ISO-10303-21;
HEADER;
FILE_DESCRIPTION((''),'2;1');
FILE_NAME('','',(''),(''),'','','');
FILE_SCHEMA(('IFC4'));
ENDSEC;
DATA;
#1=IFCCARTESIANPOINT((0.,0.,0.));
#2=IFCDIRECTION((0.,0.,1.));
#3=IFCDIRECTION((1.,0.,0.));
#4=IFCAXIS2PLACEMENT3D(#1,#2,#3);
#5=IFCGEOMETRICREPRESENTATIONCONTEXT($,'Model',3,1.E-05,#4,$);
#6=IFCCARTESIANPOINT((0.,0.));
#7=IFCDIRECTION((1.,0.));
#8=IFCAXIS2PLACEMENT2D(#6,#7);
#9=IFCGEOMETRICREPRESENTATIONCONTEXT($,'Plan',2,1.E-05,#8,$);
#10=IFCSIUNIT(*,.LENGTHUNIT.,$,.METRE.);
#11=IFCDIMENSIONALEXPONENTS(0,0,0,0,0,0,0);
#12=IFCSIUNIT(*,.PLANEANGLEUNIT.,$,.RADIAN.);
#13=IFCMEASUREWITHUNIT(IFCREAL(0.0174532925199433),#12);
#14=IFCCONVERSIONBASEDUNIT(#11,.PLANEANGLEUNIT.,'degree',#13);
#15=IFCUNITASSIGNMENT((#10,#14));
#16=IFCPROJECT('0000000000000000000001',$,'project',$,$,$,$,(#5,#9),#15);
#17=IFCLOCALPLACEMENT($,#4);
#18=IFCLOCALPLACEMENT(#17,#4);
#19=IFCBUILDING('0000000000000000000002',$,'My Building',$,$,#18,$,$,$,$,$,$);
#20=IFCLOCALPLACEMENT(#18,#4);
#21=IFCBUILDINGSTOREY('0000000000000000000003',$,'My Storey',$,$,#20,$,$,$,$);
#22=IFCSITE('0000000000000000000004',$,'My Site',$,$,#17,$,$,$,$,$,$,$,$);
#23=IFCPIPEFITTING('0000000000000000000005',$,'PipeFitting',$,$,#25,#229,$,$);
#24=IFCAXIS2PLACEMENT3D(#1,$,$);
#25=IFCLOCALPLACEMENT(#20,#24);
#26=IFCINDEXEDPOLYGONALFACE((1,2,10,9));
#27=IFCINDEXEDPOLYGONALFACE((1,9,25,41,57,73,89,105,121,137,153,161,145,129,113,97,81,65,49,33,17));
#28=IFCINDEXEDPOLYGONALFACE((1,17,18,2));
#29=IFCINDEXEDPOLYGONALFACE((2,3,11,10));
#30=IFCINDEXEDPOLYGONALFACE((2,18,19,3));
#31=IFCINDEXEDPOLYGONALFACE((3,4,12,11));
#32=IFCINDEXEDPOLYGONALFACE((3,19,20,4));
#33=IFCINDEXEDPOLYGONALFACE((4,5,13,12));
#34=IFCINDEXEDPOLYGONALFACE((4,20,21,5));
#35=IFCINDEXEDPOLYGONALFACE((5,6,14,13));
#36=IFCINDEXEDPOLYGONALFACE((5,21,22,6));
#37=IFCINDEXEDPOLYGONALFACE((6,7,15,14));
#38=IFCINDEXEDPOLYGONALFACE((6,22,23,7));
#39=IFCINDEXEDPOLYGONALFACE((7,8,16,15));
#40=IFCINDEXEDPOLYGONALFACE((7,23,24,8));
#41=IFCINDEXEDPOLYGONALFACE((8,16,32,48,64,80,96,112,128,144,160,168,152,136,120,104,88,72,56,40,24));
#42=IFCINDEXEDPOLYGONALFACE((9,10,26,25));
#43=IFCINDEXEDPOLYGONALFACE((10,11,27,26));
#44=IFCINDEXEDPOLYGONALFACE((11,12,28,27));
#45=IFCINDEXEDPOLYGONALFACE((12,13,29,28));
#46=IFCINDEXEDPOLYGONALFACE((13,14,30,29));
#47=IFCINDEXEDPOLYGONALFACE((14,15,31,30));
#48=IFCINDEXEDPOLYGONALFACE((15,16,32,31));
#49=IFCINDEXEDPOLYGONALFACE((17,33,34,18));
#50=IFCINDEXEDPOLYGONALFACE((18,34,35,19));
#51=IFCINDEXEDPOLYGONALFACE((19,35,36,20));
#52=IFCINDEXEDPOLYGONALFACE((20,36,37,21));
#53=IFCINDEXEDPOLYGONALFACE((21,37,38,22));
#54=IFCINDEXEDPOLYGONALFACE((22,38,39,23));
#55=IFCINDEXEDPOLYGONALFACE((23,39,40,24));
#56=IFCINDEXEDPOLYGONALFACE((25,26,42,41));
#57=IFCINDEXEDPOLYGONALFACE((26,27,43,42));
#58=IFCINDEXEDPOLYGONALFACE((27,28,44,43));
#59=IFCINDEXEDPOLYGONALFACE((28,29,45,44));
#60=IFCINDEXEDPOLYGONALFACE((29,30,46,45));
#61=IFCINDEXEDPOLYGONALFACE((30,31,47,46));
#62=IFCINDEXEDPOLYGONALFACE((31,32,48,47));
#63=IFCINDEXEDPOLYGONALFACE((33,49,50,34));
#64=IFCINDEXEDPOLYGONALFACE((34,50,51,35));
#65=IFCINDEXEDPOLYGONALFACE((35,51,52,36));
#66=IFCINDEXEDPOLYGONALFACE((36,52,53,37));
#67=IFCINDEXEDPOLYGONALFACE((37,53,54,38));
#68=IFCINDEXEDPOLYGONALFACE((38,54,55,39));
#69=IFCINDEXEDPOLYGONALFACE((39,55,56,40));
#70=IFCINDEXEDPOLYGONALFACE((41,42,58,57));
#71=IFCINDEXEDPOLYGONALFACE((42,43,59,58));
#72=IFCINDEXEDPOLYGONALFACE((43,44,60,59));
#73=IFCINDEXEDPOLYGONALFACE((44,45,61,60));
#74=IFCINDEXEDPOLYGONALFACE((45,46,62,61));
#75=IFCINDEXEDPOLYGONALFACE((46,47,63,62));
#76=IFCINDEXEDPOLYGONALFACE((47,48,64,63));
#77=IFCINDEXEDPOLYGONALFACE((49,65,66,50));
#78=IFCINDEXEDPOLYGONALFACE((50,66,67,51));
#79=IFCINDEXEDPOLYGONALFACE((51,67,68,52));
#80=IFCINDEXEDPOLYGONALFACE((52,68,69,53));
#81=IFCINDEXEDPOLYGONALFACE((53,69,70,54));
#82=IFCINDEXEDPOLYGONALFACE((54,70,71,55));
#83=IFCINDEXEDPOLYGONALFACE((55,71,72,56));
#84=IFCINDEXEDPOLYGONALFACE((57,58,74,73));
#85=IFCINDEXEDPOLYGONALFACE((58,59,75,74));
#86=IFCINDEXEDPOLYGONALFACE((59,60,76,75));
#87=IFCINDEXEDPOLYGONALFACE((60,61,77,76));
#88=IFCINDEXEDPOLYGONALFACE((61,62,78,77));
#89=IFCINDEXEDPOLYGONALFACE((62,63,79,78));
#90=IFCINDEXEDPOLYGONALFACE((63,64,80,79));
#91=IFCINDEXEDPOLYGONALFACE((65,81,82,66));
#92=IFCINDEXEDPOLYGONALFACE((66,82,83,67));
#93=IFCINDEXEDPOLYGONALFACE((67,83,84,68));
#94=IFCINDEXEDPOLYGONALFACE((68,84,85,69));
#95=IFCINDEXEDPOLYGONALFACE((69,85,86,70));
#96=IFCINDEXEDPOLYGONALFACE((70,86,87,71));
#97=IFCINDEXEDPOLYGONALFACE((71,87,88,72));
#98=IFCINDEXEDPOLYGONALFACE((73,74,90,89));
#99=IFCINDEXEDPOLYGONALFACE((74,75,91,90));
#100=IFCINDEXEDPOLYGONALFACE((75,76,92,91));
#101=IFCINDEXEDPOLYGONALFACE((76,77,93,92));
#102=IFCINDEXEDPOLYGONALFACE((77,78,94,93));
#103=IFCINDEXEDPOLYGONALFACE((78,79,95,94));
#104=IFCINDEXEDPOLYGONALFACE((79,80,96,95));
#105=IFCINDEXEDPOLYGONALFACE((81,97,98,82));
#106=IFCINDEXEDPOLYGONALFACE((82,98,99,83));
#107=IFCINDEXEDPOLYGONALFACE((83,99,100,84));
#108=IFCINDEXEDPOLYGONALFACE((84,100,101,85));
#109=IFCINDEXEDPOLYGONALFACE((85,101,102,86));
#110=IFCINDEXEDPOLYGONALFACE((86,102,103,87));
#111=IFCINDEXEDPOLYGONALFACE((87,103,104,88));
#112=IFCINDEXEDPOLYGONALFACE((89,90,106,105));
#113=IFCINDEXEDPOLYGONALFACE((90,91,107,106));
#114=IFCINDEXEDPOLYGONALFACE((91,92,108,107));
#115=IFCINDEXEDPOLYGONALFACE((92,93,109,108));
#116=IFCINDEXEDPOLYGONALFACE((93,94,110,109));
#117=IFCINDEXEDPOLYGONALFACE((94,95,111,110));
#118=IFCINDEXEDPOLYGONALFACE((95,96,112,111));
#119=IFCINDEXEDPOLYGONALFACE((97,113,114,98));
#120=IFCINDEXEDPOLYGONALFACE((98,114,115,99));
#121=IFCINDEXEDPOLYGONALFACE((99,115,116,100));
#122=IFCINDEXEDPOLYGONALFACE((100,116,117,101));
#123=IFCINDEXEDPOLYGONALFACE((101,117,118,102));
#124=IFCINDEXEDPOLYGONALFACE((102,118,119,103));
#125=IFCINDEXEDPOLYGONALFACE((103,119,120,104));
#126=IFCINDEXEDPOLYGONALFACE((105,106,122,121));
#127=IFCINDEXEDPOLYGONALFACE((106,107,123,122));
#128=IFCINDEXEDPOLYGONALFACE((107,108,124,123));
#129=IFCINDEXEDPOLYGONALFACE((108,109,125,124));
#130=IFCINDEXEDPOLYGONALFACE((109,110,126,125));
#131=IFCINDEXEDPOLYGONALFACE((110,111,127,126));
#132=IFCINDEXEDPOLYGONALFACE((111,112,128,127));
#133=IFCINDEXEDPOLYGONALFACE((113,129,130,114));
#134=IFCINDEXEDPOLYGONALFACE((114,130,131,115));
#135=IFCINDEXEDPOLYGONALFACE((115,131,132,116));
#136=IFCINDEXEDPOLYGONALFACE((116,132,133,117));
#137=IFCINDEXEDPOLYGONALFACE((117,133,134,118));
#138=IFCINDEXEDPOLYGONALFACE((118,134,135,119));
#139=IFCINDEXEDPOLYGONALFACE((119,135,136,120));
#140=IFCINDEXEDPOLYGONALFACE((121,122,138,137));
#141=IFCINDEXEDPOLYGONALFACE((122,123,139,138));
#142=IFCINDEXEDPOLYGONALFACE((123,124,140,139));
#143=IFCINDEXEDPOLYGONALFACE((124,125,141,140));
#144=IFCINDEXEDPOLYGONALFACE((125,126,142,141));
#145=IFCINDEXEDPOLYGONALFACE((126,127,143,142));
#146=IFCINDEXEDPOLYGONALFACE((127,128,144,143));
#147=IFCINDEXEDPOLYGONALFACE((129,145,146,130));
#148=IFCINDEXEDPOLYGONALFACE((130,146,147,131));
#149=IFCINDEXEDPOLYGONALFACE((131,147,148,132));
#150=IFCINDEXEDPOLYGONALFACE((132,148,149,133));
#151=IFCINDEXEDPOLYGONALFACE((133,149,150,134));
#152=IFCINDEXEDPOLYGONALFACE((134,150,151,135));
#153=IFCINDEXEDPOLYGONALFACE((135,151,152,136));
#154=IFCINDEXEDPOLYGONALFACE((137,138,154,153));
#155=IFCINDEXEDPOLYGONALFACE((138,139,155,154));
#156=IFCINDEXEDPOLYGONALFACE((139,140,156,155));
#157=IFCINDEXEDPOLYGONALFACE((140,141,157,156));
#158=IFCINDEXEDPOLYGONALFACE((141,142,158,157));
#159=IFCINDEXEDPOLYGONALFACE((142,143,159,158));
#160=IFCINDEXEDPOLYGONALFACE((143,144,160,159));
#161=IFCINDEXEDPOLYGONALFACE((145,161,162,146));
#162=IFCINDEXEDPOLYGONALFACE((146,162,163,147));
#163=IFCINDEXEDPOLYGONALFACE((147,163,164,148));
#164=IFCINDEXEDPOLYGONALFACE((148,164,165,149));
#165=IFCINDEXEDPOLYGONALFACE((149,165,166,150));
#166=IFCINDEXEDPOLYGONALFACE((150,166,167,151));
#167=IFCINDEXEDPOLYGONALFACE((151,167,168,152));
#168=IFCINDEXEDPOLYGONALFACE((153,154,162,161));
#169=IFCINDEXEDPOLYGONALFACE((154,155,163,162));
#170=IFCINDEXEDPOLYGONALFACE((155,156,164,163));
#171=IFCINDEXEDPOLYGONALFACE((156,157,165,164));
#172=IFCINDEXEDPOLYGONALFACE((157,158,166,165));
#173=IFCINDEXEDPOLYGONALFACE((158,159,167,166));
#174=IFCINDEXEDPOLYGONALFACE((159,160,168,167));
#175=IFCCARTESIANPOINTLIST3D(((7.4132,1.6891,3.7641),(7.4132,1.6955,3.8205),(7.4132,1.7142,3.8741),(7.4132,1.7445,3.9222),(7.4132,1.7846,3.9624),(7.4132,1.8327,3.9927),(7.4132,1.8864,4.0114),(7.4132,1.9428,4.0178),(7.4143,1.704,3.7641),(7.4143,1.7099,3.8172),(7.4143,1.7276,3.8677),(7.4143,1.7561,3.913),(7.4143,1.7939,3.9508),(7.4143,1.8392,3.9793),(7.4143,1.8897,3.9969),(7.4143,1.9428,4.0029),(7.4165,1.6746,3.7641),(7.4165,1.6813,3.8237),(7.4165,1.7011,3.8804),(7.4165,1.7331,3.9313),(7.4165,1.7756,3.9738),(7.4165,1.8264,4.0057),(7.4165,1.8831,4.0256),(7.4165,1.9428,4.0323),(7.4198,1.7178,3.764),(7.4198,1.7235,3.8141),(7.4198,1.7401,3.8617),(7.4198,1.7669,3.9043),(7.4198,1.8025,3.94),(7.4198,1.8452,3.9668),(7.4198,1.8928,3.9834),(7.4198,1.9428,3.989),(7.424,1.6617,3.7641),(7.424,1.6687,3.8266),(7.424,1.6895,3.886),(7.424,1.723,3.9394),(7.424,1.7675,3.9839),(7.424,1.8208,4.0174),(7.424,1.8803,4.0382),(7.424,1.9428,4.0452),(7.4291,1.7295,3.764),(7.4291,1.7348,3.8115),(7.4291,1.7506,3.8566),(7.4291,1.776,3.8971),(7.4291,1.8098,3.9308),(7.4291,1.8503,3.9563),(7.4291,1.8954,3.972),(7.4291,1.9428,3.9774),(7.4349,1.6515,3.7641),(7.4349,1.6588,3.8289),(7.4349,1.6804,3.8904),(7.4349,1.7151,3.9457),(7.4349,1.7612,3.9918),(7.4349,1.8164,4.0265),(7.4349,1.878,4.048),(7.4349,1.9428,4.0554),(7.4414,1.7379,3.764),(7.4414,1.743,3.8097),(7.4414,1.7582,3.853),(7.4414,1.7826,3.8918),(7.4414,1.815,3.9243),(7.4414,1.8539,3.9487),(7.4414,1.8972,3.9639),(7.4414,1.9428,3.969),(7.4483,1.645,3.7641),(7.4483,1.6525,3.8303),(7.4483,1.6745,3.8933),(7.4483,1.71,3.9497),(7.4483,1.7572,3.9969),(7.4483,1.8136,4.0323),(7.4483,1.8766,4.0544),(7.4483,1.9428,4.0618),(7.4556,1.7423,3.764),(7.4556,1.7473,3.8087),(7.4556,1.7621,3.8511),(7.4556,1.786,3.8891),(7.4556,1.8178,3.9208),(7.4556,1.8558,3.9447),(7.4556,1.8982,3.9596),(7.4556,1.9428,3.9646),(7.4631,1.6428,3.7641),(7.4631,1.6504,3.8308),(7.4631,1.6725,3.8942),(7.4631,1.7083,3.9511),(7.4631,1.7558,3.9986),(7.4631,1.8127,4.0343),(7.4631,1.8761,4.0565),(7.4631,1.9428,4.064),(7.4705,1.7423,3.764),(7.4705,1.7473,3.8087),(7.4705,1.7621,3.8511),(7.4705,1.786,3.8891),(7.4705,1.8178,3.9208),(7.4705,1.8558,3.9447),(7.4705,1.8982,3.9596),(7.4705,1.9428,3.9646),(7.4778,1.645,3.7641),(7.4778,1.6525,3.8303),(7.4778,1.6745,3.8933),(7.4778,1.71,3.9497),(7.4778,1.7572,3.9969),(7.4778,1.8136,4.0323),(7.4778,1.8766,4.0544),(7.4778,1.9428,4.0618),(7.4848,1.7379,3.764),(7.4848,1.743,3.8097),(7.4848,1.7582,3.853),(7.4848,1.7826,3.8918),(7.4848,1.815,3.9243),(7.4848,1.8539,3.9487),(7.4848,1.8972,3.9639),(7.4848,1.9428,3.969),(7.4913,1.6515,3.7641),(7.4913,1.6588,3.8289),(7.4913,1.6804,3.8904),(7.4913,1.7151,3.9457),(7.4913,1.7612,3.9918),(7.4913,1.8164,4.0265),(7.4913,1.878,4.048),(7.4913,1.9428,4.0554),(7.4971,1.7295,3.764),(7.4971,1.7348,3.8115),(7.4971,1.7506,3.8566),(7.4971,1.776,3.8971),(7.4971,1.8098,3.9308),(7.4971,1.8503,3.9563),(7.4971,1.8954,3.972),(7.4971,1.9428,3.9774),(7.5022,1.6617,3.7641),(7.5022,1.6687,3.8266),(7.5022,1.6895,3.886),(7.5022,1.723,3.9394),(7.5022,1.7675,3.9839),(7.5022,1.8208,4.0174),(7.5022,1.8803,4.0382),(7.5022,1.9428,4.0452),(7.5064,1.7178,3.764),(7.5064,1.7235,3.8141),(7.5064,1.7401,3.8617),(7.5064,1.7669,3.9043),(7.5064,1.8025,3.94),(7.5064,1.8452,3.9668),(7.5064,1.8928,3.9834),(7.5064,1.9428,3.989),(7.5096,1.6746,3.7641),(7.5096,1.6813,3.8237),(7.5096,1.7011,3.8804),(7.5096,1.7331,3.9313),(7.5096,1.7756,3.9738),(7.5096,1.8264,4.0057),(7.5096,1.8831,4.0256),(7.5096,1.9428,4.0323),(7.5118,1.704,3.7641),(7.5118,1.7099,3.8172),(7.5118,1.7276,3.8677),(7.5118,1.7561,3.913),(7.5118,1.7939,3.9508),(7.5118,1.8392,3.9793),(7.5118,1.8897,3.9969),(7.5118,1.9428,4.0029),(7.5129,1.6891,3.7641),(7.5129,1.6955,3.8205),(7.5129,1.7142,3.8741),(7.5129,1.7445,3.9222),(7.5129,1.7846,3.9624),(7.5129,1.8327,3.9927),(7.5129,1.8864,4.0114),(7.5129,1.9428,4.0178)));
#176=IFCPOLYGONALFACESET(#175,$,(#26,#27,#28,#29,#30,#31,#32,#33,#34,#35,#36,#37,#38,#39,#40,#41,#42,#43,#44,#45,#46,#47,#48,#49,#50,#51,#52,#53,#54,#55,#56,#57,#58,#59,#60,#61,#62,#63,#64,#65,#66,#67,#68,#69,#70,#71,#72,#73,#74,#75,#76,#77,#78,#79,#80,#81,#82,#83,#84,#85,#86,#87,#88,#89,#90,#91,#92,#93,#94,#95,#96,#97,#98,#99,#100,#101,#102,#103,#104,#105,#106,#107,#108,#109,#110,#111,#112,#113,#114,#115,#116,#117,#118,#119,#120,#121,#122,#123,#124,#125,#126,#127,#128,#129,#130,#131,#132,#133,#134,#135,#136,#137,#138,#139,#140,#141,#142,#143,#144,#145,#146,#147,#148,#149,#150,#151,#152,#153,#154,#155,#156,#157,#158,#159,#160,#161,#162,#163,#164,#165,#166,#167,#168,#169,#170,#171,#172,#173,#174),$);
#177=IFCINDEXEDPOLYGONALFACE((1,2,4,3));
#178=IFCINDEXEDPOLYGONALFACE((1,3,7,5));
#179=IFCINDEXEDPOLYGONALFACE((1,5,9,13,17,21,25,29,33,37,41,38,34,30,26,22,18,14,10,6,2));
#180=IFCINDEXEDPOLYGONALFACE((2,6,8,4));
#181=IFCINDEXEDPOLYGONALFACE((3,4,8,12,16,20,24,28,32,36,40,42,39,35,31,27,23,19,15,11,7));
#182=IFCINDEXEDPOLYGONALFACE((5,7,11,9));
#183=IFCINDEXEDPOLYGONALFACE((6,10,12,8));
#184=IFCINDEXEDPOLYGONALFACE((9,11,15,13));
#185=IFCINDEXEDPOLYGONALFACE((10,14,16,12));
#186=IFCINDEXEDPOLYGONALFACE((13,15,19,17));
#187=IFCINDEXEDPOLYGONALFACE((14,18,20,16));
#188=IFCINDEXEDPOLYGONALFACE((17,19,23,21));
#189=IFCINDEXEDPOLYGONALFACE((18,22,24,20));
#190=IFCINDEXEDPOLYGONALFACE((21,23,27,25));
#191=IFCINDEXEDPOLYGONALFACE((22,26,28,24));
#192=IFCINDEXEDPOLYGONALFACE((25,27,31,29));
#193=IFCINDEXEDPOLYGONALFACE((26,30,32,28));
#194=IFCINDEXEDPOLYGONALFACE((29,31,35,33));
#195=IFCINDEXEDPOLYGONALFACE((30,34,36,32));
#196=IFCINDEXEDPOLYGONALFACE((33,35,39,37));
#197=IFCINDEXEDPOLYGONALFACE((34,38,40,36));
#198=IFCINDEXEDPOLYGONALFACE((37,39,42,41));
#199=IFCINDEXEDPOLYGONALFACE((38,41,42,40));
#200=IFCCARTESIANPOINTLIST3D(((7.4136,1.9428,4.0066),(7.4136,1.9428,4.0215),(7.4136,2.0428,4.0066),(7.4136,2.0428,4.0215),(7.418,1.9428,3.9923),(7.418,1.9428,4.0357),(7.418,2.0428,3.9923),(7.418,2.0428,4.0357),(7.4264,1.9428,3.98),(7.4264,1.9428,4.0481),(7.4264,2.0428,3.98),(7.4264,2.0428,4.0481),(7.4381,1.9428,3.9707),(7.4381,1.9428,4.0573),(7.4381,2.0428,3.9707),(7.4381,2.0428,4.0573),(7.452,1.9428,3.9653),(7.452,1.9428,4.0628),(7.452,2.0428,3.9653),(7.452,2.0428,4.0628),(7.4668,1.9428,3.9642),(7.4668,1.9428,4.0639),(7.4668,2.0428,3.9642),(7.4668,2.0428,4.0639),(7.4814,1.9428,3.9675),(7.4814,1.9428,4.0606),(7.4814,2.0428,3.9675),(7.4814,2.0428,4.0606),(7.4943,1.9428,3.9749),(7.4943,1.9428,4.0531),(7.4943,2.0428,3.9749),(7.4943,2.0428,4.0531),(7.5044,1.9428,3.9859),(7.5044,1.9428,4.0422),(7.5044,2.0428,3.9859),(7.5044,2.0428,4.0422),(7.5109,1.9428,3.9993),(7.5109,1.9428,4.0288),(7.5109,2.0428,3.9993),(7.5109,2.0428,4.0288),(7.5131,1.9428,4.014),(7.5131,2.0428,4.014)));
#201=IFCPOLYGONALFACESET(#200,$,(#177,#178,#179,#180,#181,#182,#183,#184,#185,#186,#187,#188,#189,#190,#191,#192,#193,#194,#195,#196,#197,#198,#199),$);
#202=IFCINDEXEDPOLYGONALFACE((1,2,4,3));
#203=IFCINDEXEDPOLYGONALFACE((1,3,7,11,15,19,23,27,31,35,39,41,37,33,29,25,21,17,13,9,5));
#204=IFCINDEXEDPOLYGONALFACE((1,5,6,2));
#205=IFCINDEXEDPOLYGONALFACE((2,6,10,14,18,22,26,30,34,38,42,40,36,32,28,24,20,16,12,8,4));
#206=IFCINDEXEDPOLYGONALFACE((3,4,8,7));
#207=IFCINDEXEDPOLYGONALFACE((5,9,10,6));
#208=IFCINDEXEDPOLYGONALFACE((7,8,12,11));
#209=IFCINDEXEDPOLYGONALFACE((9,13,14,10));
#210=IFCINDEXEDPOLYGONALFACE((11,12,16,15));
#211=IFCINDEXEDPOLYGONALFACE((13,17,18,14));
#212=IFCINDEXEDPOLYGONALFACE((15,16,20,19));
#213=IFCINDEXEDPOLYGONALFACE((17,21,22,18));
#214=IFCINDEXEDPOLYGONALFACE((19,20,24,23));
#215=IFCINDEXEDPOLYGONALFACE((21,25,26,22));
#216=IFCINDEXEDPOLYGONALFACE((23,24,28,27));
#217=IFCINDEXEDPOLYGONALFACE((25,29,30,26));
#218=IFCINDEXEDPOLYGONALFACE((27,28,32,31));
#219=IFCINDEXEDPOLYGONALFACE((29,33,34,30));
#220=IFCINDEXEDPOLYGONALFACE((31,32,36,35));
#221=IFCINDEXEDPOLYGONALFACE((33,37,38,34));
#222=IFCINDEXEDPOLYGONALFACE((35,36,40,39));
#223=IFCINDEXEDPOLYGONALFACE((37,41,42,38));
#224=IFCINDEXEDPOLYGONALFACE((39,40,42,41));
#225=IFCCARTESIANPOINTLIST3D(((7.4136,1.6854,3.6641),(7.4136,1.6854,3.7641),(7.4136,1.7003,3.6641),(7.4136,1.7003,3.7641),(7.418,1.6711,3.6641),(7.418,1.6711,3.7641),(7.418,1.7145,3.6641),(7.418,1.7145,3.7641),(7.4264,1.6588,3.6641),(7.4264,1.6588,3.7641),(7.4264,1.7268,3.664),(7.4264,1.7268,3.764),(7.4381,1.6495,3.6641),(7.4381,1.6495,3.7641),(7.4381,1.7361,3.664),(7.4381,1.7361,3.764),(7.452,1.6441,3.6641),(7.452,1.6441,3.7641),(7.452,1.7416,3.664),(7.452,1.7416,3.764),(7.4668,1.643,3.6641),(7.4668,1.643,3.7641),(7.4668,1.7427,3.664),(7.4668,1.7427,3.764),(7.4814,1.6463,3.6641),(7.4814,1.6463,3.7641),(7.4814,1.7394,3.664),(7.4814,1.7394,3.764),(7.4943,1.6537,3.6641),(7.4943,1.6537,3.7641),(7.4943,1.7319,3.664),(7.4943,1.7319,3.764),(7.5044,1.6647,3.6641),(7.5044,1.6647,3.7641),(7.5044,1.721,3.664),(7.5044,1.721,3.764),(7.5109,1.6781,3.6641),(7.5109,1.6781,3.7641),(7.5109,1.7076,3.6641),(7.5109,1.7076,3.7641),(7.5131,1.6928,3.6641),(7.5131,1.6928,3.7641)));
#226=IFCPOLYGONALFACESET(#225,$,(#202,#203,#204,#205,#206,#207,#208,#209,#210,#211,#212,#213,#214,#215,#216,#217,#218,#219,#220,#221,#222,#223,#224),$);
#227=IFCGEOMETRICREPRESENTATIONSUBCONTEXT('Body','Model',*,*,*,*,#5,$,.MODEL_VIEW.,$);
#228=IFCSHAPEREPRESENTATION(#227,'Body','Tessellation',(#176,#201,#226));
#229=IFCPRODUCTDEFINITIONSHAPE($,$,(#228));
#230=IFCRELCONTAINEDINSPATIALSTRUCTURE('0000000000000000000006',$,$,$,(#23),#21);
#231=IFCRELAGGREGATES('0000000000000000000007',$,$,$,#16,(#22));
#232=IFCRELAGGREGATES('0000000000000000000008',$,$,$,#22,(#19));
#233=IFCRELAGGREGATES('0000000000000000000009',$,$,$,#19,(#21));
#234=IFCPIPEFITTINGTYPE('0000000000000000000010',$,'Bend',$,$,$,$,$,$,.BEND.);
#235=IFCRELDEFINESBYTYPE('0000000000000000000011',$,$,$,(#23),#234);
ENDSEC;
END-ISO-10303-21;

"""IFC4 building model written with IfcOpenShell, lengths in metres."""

from ifc_helpers import new_model, entity, si_unit, converted_unit, frame, origin_with_axes, origin_2d_with_axis, place, context, subcontext, project, spatial, circle, extrude, source, transform, mapped, type_object, type_shapes, element, save


model = new_model("IFC4")

# Units and contexts
model_context = context("Model", 3, precision=1e-05, world=origin_with_axes())
plan_context = context("Plan", 2, precision=1e-05, world=origin_2d_with_axis())
body_context = subcontext(model_context, "Body", "Model", "MODEL_VIEW")
ifc_project = project(units=[si_unit("LENGTHUNIT", "METRE"), converted_unit("PLANEANGLEUNIT", "degree", entity("IfcReal", 0.0174532925199433), si_unit("PLANEANGLEUNIT", "RADIAN"), dimensions=[0, 0, 0, 0, 0, 0, 0])], contexts=[model_context, plan_context])

# Site, building, storey
site_placement = place(None, origin_with_axes())
site = spatial("IfcSite", under=ifc_project, at=site_placement, Name="My Site")
building_placement = place(site_placement, origin_with_axes())
building = spatial("IfcBuilding", under=site, at=building_placement, Name="My Building")
storey_placement = place(building_placement, origin_with_axes())
storey = spatial("IfcBuildingStorey", under=building, at=storey_placement, Name="My Storey")

# Pipe fitting
pipe_fitting_type_1 = type_object("IfcPipeFittingType", Name="Bend", PredefinedType="BEND")
shared_shape_1 = source(origin_with_axes(), body_context, "Body", "SolidModel", [
    entity("IfcSweptDiskSolid", entity("IfcIndexedPolyCurve", entity("IfcCartesianPointList3D", [[0.0, 0.0, 0.1], [0.0, -0.0732, 0.2768], [0.0, -0.25, 0.35]]), [entity("IfcArcIndex", [1, 2, 3])]), 0.05),
    extrude(circle(Radius=0.05), origin_with_axes(), (0.0, 0.0, 1.0), 0.1),
    extrude(circle(Radius=0.05), frame((0.0, -0.25, 0.35), z_axis=(0.0, -1.0, 0.000038), x_axis=(1.0, 0.0, 0.0)), (0.0, 0.0, 1.0), 0.1),
])
type_shapes(pipe_fitting_type_1, [shared_shape_1])
for number, where, z_axis, x_axis, name in (
    (1, (7.4631, 2.0428, 4.014), (0.0, -1.0, 0.0), (1.0, 0.0, 0.0), "PipeFitting"),
):
    element("IfcPipeFitting", number, at=place(storey_placement, frame(where, z_axis=z_axis, x_axis=x_axis)), inside=storey, type_object=pipe_fitting_type_1, Name=name, context=body_context, shape_type="MappedRepresentation", body=[
        mapped(shared_shape_1, transform((0.0, 0.0, 0.0), x_axis=(1.0, 0.0, 0.0), y_axis=(0.0, 1.0, 0.0), z_axis=(0.0, 0.0, 1.0), scale=1.0)),
    ])

save(model, "model.ifc")
